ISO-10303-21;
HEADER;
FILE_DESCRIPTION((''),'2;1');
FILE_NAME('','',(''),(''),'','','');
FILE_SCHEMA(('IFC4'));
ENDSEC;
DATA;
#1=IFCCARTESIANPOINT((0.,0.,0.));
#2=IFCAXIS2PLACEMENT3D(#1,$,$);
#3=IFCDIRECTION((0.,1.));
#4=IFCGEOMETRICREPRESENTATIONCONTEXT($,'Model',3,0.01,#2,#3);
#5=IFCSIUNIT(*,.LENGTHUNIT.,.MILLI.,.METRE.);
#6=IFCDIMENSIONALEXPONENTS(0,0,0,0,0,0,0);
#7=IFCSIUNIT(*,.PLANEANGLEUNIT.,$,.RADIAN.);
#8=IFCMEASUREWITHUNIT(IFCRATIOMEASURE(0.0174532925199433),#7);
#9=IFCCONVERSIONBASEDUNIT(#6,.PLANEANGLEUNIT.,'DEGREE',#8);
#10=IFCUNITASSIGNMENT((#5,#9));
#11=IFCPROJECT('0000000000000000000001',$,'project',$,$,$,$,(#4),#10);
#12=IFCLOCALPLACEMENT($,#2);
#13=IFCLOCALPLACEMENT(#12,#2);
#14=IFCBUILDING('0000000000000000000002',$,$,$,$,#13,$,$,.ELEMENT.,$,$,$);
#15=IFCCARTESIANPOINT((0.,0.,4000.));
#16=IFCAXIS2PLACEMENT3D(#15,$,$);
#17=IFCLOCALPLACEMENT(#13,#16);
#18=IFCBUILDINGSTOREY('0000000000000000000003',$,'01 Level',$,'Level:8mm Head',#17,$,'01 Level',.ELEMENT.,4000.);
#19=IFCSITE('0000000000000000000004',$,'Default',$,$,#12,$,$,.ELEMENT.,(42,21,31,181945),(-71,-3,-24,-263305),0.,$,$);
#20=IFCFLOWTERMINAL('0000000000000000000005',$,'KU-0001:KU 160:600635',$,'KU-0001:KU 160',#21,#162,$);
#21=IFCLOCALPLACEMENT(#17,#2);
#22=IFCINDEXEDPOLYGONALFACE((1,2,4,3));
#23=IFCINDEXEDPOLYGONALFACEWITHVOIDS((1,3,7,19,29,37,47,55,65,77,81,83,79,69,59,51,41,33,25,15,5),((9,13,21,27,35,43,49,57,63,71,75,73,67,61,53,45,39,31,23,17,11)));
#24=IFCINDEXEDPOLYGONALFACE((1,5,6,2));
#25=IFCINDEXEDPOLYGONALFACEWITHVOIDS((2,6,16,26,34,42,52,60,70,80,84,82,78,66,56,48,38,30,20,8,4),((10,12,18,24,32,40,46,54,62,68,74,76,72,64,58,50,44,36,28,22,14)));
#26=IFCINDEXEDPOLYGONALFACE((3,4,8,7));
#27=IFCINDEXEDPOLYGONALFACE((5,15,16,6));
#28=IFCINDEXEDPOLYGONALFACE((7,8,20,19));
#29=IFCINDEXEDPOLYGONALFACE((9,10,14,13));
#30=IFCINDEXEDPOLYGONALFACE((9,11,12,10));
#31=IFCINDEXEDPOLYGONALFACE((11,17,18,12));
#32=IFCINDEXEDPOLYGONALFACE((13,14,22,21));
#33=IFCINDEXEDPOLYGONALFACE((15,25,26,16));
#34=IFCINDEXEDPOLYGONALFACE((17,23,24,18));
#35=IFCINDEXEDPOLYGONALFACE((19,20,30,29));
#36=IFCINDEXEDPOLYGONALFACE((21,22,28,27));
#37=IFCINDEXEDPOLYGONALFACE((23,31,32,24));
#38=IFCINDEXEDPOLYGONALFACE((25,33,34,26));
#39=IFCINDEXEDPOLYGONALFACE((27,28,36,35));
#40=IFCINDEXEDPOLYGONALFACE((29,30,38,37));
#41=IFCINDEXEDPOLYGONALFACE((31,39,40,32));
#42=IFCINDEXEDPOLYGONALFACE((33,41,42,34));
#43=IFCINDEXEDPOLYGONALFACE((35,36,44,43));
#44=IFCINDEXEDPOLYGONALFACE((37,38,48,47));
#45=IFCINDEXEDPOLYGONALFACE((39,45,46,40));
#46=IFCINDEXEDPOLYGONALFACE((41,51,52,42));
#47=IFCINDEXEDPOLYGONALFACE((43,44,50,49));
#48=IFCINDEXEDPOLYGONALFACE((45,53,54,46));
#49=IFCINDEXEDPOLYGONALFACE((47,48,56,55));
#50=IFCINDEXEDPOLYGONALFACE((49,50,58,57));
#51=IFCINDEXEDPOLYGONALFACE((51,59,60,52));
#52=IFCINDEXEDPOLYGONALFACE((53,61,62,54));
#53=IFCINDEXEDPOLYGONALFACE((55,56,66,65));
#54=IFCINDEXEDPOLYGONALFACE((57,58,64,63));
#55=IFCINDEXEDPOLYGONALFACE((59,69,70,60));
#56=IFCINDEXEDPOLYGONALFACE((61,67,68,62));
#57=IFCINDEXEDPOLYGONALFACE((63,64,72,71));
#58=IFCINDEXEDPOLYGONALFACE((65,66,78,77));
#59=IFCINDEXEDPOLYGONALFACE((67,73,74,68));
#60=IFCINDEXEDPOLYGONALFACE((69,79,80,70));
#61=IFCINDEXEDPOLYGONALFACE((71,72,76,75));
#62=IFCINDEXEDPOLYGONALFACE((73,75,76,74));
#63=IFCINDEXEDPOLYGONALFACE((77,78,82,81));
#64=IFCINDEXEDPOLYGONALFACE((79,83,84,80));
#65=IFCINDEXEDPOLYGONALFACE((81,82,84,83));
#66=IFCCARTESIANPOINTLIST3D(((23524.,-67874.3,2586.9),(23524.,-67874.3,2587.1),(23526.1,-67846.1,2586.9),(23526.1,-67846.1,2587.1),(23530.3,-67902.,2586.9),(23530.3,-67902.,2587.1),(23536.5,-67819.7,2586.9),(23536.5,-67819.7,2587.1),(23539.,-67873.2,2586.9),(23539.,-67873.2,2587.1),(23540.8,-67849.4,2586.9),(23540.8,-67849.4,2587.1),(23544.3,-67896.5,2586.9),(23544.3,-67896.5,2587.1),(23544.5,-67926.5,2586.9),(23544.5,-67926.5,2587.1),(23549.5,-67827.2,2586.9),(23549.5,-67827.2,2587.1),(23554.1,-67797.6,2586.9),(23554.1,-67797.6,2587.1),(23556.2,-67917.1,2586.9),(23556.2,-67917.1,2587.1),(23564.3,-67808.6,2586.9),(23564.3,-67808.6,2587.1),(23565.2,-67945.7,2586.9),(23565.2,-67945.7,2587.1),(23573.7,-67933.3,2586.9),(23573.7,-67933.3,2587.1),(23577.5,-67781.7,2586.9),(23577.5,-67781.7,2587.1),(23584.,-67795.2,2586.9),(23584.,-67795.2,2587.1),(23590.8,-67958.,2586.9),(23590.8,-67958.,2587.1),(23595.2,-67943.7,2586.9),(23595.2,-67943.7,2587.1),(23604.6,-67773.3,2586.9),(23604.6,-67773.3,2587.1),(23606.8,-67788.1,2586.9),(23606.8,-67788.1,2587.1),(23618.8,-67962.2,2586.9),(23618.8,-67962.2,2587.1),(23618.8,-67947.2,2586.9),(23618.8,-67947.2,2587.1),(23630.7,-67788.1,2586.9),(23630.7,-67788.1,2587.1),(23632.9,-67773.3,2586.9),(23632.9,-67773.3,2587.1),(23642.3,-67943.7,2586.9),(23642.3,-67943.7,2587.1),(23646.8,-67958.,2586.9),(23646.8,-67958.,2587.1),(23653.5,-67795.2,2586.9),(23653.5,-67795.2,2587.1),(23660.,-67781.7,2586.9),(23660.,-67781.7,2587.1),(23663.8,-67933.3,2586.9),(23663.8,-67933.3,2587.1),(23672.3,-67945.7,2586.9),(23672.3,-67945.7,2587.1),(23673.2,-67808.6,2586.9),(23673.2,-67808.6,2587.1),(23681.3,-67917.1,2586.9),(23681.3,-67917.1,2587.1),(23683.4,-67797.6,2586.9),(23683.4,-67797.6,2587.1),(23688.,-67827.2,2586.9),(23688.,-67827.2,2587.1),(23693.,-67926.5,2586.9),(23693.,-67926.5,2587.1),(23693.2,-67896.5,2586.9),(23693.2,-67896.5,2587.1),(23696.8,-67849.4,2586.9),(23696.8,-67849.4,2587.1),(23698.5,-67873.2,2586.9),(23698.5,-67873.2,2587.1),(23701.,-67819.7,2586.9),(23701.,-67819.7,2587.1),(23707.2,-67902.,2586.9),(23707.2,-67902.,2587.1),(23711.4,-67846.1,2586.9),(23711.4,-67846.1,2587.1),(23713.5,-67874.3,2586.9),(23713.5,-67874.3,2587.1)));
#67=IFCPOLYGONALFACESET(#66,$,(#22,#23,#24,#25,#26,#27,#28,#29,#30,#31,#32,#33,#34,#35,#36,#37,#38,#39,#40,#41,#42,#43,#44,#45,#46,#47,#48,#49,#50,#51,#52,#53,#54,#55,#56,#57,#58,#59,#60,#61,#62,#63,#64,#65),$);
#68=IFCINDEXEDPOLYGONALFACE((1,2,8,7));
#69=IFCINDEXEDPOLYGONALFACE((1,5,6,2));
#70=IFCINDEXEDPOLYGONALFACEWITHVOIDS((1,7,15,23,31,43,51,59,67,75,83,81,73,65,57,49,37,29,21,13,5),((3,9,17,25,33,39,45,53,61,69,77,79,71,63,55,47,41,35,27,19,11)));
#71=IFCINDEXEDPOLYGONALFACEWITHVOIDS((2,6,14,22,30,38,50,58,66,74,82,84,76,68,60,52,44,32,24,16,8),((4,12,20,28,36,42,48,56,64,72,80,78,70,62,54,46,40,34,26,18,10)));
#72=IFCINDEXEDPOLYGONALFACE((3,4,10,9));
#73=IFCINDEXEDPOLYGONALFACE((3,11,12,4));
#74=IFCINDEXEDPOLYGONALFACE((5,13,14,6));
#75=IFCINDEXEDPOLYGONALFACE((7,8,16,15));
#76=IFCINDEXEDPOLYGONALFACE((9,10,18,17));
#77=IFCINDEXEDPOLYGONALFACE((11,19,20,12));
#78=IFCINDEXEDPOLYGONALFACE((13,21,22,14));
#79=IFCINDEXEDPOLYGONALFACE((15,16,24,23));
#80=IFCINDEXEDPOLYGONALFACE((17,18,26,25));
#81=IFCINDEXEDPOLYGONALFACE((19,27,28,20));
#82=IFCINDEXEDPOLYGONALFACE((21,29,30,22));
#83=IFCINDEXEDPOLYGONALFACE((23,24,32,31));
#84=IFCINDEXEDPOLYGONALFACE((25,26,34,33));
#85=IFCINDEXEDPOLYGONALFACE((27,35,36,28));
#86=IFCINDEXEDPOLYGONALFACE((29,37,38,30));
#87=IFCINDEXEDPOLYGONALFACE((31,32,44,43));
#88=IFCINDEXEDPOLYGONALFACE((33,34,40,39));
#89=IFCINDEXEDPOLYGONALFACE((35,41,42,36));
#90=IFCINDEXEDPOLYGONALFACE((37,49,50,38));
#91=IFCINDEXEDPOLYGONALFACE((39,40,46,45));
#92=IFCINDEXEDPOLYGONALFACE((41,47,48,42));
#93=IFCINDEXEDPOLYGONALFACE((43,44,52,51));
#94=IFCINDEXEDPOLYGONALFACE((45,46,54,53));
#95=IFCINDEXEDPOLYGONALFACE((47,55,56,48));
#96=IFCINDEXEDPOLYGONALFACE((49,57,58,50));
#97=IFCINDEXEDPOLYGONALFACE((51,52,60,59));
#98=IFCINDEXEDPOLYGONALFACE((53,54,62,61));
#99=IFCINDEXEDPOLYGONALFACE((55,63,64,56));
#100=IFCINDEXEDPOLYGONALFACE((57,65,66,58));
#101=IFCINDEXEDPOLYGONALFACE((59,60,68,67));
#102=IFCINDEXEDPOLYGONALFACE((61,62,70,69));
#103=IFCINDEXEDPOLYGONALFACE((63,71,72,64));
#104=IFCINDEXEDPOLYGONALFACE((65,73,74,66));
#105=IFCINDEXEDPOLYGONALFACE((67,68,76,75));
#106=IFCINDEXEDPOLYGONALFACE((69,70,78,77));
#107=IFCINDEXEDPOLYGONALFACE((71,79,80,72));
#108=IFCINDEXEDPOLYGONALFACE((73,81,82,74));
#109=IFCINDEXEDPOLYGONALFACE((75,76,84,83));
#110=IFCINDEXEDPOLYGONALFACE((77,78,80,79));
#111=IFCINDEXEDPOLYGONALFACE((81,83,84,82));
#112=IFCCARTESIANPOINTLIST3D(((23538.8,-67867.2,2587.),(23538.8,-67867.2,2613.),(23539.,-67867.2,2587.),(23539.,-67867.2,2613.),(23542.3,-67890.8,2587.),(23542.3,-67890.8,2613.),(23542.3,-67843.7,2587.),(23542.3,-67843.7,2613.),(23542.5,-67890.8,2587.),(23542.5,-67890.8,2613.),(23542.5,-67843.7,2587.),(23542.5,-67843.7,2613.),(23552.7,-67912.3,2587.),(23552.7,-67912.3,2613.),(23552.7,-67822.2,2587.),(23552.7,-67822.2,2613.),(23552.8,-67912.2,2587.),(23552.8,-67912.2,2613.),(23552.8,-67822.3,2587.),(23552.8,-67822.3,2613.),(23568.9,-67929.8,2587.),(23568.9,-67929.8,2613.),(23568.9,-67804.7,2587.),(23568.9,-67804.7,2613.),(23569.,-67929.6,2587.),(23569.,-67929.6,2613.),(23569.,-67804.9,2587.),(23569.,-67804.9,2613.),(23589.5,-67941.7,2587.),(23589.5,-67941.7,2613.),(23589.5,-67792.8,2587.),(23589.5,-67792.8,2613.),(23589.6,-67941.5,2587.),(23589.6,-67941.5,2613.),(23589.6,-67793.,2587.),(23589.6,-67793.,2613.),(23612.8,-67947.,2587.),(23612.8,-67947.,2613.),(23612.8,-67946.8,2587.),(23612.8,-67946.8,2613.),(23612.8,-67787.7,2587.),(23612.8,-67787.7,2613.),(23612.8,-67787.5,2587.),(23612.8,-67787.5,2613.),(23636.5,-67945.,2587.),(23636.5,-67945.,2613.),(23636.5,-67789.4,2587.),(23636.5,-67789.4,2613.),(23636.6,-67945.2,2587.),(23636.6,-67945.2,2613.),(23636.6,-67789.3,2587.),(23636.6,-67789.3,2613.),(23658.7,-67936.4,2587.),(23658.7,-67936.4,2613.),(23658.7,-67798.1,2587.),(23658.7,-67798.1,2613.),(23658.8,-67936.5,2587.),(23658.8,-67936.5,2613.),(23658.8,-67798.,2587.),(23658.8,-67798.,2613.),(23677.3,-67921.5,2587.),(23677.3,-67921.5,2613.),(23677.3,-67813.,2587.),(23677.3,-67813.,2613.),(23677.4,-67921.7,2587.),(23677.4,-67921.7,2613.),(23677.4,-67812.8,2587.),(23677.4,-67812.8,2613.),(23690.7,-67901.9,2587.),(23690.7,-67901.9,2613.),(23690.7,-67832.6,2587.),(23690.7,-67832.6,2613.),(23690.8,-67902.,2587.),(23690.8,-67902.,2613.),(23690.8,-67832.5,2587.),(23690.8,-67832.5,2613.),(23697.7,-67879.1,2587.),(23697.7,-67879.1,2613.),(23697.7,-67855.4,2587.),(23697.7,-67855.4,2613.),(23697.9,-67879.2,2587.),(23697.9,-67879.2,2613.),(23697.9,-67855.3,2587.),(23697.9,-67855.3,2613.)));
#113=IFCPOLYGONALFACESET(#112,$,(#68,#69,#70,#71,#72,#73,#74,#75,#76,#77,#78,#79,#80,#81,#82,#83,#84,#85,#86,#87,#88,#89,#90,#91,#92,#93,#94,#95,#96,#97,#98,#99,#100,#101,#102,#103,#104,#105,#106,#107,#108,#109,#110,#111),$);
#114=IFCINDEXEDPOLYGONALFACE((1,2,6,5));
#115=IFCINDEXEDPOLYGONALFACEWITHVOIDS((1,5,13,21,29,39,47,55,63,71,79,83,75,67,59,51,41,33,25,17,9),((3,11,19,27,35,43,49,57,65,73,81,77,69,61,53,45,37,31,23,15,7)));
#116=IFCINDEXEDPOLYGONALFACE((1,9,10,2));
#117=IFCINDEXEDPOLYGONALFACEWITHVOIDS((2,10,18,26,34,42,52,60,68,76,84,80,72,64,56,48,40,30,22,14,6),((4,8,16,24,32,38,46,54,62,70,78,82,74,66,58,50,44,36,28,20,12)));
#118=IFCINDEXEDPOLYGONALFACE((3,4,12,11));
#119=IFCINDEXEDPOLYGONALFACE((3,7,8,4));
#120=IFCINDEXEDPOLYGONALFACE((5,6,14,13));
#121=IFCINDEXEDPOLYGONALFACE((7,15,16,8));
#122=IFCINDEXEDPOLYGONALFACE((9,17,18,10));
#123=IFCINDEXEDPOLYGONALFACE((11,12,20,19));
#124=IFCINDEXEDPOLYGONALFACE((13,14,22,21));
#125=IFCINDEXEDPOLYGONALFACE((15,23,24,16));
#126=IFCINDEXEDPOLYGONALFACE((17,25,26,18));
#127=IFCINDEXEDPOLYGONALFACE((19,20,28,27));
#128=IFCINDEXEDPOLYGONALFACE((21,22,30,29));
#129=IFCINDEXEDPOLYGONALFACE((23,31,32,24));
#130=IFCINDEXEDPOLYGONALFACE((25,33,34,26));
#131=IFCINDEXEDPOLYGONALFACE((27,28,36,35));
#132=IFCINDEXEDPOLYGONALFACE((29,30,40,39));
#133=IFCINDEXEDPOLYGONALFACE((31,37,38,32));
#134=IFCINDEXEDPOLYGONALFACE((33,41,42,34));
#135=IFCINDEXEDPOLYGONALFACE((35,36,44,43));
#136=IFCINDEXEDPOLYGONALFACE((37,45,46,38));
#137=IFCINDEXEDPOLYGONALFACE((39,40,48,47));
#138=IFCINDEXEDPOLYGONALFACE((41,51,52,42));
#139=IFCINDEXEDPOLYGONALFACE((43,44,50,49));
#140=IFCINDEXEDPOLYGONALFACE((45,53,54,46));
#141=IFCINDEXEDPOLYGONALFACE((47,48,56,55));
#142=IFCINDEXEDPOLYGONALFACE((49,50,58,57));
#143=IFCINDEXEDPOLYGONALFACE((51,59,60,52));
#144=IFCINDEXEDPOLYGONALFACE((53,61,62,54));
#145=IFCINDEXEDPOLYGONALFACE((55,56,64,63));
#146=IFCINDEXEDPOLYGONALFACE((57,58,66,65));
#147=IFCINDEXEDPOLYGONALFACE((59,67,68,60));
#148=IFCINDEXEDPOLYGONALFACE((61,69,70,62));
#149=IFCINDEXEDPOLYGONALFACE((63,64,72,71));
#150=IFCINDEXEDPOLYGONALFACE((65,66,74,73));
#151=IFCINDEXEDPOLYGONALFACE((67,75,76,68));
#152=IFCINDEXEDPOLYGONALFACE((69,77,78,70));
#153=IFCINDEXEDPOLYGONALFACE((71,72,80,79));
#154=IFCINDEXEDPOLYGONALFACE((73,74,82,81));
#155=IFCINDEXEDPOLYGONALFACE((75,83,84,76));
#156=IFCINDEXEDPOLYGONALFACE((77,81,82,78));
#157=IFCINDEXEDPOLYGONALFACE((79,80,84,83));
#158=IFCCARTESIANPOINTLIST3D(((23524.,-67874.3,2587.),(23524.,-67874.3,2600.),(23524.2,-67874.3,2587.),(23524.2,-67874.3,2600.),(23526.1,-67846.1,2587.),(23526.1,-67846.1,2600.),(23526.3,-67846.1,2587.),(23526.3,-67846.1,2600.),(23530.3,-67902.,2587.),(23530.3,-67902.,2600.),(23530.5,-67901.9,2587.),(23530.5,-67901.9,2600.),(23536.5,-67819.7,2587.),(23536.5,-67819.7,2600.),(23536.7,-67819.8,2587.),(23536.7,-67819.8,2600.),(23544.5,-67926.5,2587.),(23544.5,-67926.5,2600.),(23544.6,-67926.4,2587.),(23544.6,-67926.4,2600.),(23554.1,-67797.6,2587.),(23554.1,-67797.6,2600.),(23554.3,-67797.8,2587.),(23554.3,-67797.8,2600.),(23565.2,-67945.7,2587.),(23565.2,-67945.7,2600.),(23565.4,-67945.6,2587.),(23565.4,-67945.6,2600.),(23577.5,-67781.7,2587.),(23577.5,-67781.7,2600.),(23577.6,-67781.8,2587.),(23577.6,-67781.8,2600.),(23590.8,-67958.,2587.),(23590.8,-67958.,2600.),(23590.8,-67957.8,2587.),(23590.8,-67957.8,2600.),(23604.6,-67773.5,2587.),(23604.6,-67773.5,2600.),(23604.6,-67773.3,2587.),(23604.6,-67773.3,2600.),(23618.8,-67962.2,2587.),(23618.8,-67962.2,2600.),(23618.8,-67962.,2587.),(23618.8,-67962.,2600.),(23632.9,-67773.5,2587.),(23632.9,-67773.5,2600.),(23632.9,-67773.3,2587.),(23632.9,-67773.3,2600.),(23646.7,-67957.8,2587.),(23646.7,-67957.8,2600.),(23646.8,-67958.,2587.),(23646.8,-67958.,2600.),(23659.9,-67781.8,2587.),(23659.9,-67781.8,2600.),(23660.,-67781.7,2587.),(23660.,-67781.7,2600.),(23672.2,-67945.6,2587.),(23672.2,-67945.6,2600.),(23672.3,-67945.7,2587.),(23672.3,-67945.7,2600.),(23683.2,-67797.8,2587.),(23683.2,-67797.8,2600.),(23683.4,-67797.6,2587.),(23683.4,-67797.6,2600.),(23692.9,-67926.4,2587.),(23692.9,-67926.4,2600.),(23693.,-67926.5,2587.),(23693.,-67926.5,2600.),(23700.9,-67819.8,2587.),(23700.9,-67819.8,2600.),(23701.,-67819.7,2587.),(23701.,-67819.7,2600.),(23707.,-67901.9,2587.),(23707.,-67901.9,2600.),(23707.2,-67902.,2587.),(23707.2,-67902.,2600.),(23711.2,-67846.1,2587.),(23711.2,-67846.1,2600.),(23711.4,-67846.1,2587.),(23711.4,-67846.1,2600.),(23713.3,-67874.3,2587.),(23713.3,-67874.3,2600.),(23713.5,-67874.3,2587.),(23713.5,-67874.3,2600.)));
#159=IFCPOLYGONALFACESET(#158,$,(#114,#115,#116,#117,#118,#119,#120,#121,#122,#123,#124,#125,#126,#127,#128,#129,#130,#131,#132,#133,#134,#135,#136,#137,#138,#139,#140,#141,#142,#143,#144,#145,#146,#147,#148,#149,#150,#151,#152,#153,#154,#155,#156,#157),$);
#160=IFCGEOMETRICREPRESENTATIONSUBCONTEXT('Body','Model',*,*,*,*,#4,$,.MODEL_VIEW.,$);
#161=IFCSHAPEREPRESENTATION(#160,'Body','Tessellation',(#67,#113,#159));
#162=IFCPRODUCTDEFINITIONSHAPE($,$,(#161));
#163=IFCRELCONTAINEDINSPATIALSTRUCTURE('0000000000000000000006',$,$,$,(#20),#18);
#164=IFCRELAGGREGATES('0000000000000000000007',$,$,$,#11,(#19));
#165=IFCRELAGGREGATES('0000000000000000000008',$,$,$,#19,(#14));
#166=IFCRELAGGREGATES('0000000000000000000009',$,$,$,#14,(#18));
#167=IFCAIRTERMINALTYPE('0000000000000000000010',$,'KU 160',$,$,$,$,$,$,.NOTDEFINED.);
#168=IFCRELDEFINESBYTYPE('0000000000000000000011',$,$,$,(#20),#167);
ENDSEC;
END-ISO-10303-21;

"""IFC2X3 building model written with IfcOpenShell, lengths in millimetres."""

from ifc_helpers import new_model, entity, si_unit, converted_unit, direction, frame, frame_2d, origin, place, context, subcontext, project, spatial, hollow_circle, extrude, source, transform, mapped, type_object, type_shapes, element, save


model = new_model("IFC2X3")

# Units and contexts
model_context = context("Model", 3, precision=0.01, world=origin(), true_north=direction((0.0, 1.0)))
body_context = subcontext(model_context, "Body", "Model", "MODEL_VIEW")
ifc_project = project(units=[si_unit("LENGTHUNIT", "METRE", prefix="MILLI"), converted_unit("PLANEANGLEUNIT", "DEGREE", entity("IfcRatioMeasure", 0.0174532925199433), si_unit("PLANEANGLEUNIT", "RADIAN"), dimensions=[0, 0, 0, 0, 0, 0, 0])], contexts=[model_context])

# Site, building, storey
site_placement = place(None, origin())
site = spatial("IfcSite", under=ifc_project, at=site_placement, Name="Default", CompositionType="ELEMENT", RefLatitude=(42, 21, 31, 181945), RefLongitude=(-71, -3, -24, -263305), RefElevation=0.0)
building_placement = place(site_placement, origin())
building = spatial("IfcBuilding", under=site, at=building_placement, CompositionType="ELEMENT")
storey_placement = place(building_placement, frame((0.0, 0.0, 4000.0)))
storey = spatial("IfcBuildingStorey", under=building, at=storey_placement, Name="01 Level", ObjectType="Level:8mm Head", LongName="01 Level", CompositionType="ELEMENT", Elevation=4000.0)

# Flow terminal
air_terminal_type_1 = type_object("IfcAirTerminalType", Name="KU 160", PredefinedType="NOTDEFINED")
shared_shape_1 = source(origin(), body_context, "Body", "SweptSolid", [
    extrude(hollow_circle(Radius=95.0, WallThickness=15.0, at=frame_2d((0.0, 0.0), x_axis=(1.0, 0.0))), frame((12.9, 0.0, 0.0), z_axis=(1.0, 0.0, 0.0), x_axis=(0.0, -1.0, 0.0)), (0.0, 0.0, 1.0), 0.2),
    extrude(hollow_circle(Radius=80.0, WallThickness=0.2, at=frame_2d((0.0, 0.0), x_axis=(1.0, 0.0))), frame((-13.0, 0.0, 0.0), z_axis=(1.0, 0.0, 0.0), x_axis=(0.0, 0.0, -1.0)), (0.0, 0.0, 1.0), 26.0),
    extrude(hollow_circle(Radius=95.0, WallThickness=0.2, at=frame_2d((0.0, 0.0), x_axis=(1.0, 0.0))), frame((0.0, 0.0, 0.0), z_axis=(1.0, 0.0, 0.0), x_axis=(0.0, -1.0, 0.0)), (0.0, 0.0, 1.0), 13.0),
])
type_shapes(air_terminal_type_1, [shared_shape_1])
for number, where, z_axis, x_axis, name in (
    (1, (23618.8, -67867.2, 2600.0), (1.0, 0.0, 0.0), (0.0, 0.0, -1.0), "KU-0001:KU 160:600635"),
):
    element("IfcFlowTerminal", number, at=place(storey_placement, frame(where, z_axis=z_axis, x_axis=x_axis)), inside=storey, type_object=air_terminal_type_1, Name=name, ObjectType="KU-0001:KU 160", context=body_context, shape_type="MappedRepresentation", body=[
        mapped(shared_shape_1, transform((0.0, 0.0, 0.0), scale=1.0)),
    ])

save(model, "model.ifc")
